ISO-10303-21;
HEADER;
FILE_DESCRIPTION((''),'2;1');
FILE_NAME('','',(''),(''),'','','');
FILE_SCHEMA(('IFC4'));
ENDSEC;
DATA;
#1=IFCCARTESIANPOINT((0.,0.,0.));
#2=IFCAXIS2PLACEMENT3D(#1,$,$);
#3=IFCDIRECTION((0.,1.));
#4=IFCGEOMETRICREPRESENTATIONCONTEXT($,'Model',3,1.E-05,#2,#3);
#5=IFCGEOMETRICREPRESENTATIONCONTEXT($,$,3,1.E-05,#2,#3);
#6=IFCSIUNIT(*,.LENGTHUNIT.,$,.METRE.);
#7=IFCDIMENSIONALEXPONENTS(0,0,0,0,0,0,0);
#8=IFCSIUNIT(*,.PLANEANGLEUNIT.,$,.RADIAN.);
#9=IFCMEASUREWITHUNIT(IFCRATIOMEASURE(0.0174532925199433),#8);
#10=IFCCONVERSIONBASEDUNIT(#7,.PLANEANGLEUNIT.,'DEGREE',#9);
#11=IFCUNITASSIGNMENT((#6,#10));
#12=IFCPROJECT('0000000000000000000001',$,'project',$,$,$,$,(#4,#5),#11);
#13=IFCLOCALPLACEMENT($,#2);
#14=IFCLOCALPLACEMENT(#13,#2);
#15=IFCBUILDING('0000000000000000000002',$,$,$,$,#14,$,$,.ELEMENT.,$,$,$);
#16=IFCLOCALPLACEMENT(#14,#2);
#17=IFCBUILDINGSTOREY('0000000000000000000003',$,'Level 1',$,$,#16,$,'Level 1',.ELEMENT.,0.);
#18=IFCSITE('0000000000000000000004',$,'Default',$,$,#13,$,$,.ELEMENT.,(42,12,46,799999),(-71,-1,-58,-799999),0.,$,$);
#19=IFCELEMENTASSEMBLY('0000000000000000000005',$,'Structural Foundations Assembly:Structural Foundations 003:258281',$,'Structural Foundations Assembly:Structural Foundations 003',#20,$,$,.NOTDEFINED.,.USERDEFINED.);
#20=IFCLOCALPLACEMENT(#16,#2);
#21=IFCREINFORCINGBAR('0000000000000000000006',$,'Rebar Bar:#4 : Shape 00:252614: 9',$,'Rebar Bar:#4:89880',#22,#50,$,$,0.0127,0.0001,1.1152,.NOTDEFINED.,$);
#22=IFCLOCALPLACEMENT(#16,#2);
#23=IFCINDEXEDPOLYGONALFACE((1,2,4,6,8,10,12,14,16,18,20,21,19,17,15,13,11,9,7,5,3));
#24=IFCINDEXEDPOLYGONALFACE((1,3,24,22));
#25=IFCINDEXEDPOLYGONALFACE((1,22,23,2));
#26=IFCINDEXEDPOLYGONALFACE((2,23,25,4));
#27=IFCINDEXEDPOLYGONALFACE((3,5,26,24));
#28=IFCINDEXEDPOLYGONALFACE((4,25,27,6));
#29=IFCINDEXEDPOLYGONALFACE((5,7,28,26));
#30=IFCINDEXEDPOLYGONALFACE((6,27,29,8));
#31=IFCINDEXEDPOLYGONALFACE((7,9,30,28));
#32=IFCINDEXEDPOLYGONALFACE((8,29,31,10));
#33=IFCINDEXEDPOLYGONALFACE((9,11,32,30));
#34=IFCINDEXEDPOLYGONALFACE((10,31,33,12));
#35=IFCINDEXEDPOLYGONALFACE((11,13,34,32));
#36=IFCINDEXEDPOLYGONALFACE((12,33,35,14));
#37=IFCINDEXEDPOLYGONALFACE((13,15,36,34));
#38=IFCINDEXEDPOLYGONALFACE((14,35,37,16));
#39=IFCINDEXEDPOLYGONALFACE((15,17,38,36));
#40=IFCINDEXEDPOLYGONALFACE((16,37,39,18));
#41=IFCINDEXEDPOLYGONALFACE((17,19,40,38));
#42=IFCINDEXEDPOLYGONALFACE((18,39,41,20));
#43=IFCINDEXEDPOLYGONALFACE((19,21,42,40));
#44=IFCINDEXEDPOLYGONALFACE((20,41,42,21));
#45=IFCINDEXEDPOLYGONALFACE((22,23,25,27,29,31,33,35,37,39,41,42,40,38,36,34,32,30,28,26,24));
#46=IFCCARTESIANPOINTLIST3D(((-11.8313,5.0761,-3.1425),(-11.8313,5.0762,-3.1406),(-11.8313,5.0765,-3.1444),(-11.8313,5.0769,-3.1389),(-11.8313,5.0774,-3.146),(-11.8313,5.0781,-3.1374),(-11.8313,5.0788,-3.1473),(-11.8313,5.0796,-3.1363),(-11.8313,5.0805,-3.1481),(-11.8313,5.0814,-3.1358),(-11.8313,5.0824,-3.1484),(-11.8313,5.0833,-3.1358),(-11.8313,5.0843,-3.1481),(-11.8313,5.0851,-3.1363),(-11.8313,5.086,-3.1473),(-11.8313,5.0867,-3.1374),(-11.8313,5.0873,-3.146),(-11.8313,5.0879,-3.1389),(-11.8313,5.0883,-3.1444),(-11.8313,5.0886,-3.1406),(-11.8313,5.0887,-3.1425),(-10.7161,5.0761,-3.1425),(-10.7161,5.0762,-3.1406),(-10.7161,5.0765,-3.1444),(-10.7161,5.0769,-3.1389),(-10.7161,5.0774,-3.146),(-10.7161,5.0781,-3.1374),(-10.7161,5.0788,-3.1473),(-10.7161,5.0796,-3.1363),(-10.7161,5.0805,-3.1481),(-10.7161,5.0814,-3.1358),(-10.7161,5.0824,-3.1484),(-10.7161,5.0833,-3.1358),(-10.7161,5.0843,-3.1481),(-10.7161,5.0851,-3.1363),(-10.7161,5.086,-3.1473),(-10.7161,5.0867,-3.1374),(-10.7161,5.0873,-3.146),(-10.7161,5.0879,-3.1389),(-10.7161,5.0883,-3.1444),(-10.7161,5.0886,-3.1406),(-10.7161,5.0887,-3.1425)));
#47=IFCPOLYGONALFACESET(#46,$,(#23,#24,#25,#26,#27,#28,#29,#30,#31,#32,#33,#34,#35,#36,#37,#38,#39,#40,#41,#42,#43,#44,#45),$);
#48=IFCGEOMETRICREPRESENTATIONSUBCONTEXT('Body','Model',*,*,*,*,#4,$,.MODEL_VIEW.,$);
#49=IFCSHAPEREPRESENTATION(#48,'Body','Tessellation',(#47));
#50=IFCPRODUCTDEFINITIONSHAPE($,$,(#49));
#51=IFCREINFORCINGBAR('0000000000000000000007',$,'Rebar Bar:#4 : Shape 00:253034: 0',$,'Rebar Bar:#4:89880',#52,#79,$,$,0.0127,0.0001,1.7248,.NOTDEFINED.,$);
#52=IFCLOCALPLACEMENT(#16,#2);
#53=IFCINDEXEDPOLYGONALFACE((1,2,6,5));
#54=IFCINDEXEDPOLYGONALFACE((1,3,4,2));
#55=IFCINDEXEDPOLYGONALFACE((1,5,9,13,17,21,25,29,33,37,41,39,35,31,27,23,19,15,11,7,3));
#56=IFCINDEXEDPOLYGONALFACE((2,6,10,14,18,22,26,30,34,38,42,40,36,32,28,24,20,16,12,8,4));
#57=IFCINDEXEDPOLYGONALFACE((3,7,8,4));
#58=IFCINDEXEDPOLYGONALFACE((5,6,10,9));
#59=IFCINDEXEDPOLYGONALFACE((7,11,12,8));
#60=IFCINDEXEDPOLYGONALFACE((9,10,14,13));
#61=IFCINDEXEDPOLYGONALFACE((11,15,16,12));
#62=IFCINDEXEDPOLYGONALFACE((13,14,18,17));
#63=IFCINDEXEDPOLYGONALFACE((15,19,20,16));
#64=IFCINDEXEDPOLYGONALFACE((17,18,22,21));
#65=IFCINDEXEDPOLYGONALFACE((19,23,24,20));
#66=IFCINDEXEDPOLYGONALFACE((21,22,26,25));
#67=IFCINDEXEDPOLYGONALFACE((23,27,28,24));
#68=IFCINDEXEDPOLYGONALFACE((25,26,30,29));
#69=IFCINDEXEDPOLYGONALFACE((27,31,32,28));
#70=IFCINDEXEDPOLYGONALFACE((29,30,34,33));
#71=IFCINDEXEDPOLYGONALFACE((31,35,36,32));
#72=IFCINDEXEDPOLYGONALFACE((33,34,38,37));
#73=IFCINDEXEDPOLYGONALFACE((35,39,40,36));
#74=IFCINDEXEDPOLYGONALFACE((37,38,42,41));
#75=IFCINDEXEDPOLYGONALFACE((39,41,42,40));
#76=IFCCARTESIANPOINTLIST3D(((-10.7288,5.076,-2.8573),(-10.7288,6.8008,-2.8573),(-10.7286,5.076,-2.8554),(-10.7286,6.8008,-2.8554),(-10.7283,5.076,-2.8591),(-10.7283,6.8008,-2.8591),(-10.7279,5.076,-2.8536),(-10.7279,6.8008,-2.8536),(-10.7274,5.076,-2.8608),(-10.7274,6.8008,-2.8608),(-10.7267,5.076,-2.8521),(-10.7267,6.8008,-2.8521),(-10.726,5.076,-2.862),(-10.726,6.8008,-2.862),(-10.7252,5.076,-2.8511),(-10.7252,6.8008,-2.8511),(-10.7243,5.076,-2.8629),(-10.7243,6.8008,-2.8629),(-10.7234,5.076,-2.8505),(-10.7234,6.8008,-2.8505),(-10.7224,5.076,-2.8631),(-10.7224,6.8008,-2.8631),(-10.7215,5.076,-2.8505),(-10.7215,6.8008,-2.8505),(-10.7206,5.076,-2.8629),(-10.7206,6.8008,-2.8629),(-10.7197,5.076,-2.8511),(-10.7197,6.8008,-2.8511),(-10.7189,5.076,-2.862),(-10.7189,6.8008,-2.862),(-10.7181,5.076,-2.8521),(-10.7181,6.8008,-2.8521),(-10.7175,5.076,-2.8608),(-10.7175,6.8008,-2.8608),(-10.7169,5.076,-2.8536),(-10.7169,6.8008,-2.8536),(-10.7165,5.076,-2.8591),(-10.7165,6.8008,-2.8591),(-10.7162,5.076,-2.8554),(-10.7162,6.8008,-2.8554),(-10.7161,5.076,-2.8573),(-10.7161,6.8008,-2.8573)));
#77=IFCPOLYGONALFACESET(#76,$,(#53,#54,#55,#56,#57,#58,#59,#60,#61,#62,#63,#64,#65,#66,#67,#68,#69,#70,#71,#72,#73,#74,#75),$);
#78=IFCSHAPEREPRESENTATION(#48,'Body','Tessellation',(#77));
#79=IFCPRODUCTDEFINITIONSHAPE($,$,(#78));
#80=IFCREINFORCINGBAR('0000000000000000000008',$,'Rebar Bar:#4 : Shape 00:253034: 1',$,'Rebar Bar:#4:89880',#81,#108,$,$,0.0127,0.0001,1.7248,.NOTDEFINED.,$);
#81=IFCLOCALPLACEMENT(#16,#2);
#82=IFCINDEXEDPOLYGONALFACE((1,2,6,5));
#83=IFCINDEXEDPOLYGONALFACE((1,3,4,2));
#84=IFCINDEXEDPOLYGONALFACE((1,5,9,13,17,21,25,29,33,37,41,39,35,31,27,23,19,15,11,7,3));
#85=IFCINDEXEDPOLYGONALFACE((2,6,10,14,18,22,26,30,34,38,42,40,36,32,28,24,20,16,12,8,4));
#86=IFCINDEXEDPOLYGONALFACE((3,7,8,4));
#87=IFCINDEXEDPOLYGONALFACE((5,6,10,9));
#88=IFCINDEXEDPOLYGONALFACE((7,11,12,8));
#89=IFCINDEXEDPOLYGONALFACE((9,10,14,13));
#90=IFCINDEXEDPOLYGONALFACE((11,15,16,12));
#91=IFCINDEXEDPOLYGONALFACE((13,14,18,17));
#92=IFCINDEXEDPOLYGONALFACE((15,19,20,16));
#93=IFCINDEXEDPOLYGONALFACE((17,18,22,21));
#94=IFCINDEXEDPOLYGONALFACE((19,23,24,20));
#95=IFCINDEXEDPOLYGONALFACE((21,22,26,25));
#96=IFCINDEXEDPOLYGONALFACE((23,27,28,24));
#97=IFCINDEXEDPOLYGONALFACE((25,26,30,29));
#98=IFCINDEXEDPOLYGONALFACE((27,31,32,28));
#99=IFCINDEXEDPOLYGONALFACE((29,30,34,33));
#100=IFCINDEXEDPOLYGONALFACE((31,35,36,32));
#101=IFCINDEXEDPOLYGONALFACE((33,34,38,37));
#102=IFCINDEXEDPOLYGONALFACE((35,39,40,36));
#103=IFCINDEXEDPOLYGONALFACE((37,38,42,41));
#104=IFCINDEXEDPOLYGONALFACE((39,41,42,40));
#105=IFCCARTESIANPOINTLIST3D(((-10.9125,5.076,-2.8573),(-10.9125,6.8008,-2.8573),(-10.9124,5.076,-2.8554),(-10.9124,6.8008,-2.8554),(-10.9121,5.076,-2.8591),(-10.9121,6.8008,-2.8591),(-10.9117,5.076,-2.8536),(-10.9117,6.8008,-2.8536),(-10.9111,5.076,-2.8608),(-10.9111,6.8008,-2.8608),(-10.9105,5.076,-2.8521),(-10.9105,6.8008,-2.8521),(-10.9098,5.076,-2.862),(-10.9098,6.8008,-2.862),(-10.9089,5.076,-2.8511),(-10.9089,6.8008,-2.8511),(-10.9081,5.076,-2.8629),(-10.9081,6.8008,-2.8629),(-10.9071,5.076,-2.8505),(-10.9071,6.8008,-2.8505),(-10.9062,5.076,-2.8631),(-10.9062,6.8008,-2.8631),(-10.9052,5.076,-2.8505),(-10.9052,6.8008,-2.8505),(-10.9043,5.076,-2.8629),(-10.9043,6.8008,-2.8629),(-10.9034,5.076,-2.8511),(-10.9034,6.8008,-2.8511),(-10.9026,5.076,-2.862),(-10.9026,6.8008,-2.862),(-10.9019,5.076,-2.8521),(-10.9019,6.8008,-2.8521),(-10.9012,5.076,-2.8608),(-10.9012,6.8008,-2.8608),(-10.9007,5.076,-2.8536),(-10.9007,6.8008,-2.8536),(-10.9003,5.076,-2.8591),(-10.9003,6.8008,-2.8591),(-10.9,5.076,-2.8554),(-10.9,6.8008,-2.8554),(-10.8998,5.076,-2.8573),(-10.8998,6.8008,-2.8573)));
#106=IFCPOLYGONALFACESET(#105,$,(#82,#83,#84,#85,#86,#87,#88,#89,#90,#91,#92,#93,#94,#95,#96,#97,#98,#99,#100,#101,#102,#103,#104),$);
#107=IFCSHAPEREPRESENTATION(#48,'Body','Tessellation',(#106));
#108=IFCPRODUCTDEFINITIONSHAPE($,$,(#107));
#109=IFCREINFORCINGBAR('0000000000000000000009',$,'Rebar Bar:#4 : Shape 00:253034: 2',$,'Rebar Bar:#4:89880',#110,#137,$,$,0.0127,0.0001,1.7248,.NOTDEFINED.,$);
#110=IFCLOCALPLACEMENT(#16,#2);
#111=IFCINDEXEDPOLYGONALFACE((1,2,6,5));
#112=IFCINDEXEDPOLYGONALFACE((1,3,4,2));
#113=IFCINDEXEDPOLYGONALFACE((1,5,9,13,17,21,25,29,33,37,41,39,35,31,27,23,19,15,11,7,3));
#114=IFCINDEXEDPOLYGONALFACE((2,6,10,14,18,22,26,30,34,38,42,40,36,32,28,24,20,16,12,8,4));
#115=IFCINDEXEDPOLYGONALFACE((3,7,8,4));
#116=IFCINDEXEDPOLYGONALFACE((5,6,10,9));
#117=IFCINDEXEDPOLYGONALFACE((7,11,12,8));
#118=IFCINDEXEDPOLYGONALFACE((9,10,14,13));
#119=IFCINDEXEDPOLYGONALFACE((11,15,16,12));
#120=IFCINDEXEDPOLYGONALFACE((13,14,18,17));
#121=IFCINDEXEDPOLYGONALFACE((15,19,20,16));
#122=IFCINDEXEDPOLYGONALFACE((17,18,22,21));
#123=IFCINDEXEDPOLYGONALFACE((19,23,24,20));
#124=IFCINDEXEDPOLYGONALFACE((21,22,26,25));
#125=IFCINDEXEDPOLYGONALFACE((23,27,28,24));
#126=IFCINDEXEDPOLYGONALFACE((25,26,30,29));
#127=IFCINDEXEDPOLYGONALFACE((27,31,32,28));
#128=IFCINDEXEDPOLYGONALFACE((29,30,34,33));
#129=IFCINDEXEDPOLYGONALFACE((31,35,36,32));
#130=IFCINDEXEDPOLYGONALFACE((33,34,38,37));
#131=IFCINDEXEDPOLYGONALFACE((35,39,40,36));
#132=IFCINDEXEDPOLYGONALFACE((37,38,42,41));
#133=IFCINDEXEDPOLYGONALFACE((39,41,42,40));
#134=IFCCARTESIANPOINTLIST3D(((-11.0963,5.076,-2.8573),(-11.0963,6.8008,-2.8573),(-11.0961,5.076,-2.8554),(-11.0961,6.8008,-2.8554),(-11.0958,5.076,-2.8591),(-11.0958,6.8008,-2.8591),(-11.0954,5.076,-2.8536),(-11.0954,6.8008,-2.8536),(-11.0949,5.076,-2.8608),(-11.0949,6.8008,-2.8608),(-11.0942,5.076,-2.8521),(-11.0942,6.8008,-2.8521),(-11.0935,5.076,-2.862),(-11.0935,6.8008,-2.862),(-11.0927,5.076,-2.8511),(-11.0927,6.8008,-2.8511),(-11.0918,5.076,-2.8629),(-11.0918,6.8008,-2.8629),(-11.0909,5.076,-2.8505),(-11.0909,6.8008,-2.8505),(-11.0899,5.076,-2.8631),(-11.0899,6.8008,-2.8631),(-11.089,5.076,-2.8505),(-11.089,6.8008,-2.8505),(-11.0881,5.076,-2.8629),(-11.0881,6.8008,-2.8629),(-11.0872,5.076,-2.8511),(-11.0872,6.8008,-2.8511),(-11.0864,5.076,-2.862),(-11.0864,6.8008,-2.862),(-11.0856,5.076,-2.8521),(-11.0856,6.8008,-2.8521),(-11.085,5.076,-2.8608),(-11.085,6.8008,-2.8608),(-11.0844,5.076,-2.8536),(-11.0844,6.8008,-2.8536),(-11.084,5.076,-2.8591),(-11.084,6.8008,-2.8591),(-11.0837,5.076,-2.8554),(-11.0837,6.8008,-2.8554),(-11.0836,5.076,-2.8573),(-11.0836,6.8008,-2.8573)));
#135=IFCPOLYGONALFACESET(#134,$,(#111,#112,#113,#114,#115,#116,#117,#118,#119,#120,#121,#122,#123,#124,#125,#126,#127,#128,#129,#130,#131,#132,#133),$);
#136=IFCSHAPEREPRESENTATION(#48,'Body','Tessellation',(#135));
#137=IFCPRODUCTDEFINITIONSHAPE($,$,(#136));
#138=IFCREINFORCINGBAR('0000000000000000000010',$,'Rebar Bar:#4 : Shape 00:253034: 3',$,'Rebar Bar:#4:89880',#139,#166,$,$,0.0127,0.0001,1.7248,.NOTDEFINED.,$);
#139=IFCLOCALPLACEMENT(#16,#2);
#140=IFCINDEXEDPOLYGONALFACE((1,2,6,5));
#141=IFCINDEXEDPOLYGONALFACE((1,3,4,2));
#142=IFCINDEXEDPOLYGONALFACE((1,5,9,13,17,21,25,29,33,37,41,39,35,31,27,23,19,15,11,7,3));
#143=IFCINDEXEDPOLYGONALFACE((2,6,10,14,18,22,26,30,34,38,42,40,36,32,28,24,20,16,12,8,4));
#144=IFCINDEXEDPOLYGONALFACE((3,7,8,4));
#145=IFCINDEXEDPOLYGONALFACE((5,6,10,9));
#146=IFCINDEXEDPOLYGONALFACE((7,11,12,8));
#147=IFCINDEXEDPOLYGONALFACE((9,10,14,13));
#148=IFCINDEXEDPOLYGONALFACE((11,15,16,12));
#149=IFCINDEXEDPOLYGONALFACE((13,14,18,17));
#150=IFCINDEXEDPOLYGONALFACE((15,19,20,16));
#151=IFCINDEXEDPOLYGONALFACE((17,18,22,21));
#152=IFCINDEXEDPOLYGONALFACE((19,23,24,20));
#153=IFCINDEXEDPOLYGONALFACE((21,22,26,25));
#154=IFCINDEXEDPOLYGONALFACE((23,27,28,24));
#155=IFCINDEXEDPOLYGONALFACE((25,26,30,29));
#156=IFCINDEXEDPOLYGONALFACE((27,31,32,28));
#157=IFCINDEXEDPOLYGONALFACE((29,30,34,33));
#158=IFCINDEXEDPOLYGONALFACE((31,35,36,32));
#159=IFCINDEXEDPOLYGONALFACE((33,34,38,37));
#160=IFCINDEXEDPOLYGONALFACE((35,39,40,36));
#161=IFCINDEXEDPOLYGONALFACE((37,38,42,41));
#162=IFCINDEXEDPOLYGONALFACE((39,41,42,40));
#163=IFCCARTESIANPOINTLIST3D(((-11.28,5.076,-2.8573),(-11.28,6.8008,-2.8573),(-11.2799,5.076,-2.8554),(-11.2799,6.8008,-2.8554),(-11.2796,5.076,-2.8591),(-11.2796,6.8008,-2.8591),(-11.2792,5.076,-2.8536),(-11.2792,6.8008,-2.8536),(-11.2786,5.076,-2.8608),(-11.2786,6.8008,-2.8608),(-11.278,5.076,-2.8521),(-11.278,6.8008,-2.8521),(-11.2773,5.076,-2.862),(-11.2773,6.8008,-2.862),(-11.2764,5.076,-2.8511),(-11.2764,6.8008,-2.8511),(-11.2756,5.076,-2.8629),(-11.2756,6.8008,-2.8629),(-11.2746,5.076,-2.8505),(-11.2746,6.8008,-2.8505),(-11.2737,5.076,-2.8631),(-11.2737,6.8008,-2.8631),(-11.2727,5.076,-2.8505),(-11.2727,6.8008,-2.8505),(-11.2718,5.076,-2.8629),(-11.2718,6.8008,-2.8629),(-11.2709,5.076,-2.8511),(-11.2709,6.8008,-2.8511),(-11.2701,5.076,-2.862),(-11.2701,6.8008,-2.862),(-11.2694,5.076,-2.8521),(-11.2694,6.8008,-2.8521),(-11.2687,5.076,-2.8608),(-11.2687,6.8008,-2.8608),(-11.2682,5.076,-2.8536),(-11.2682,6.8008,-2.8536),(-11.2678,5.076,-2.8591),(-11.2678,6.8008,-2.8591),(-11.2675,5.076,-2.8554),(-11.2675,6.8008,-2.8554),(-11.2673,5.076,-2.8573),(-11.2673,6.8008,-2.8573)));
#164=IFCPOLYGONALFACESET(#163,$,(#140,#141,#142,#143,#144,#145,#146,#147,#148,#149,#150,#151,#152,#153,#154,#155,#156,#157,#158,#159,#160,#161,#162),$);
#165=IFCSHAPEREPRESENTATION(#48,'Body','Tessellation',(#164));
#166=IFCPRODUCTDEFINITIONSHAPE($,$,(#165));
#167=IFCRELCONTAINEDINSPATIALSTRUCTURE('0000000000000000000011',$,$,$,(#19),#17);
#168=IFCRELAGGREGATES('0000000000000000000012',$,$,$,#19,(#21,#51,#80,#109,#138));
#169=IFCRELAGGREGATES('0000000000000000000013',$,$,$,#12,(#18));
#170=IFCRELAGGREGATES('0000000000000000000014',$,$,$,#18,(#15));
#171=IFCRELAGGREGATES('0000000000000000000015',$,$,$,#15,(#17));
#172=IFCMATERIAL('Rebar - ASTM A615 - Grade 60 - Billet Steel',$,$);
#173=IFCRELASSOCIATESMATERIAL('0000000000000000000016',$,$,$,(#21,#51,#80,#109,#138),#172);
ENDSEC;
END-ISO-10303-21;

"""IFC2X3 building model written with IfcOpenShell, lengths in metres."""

from ifc_helpers import new_model, entity, si_unit, converted_unit, direction, origin, place, context, subcontext, project, spatial, material, element, aggregate, save


model = new_model("IFC2X3")

# Units and contexts
model_context = context("Model", 3, precision=1e-05, world=origin(), true_north=direction((0.0, 1.0)))
context_of_model = context(None, 3, precision=1e-05, world=origin(), true_north=direction((0.0, 1.0)))
body_context = subcontext(model_context, "Body", "Model", "MODEL_VIEW")
ifc_project = project(units=[si_unit("LENGTHUNIT", "METRE"), converted_unit("PLANEANGLEUNIT", "DEGREE", entity("IfcRatioMeasure", 0.0174532925199433), si_unit("PLANEANGLEUNIT", "RADIAN"), dimensions=[0, 0, 0, 0, 0, 0, 0])], contexts=[model_context, context_of_model])

# Site, building, storey
site_placement = place(None, origin())
site = spatial("IfcSite", under=ifc_project, at=site_placement, Name="Default", CompositionType="ELEMENT", RefLatitude=(42, 12, 46, 799999), RefLongitude=(-71, -1, -58, -799999), RefElevation=0.0)
building_placement = place(site_placement, origin())
building = spatial("IfcBuilding", under=site, at=building_placement, CompositionType="ELEMENT")
storey_placement = place(building_placement, origin())
storey = spatial("IfcBuildingStorey", under=building, at=storey_placement, Name="Level 1", LongName="Level 1", CompositionType="ELEMENT", Elevation=0.0)

# Element assembly, reinforcing bars
assembly_1_placement = place(storey_placement, origin())
assembly_1 = element("IfcElementAssembly", 1, at=assembly_1_placement, inside=storey, Name="Structural Foundations Assembly:Structural Foundations 003:258281", ObjectType="Structural Foundations Assembly:Structural Foundations 003", AssemblyPlace="NOTDEFINED", PredefinedType="USERDEFINED")
ifc_material = material(Name="Rebar - ASTM A615 - Grade 60 - Billet Steel")
reinforcing_bar_1_placement = place(assembly_1_placement, origin())
reinforcing_bar_1 = element("IfcReinforcingBar", 2, at=reinforcing_bar_1_placement, material=ifc_material, Name="Rebar Bar:#4 : Shape 00:252614: 9", ObjectType="Rebar Bar:#4:89880", BarLength=1.1152, BarRole="NOTDEFINED", CrossSectionArea=0.0001, NominalDiameter=0.0127, context=body_context, shape_type="AdvancedSweptSolid", body=[
    entity("IfcSweptDiskSolid", entity("IfcCompositeCurve", [entity("IfcCompositeCurveSegment", "CONTINUOUS", True, entity("IfcPolyline", [entity("IfcCartesianPoint", [-10.7161, 5.0824, -3.142]), entity("IfcCartesianPoint", [-11.8313, 5.0824, -3.142])]))], False), 0.0063, None, 0.0, 1.0),
])
reinforcing_bar_2_placement = place(assembly_1_placement, origin())
reinforcing_bar_2 = element("IfcReinforcingBar", 3, at=reinforcing_bar_2_placement, material=ifc_material, Name="Rebar Bar:#4 : Shape 00:253034: 0", ObjectType="Rebar Bar:#4:89880", BarLength=1.7248, BarRole="NOTDEFINED", CrossSectionArea=0.0001, NominalDiameter=0.0127, context=body_context, shape_type="AdvancedSweptSolid", body=[
    entity("IfcSweptDiskSolid", entity("IfcCompositeCurve", [entity("IfcCompositeCurveSegment", "CONTINUOUS", True, entity("IfcPolyline", [entity("IfcCartesianPoint", [-10.7224, 6.8008, -2.8568]), entity("IfcCartesianPoint", [-10.7224, 5.076, -2.8568])]))], False), 0.0063, None, 0.0, 1.0),
])
reinforcing_bar_3_placement = place(assembly_1_placement, origin())
reinforcing_bar_3 = element("IfcReinforcingBar", 4, at=reinforcing_bar_3_placement, material=ifc_material, Name="Rebar Bar:#4 : Shape 00:253034: 1", ObjectType="Rebar Bar:#4:89880", BarLength=1.7248, BarRole="NOTDEFINED", CrossSectionArea=0.0001, NominalDiameter=0.0127, context=body_context, shape_type="AdvancedSweptSolid", body=[
    entity("IfcSweptDiskSolid", entity("IfcCompositeCurve", [entity("IfcCompositeCurveSegment", "CONTINUOUS", True, entity("IfcPolyline", [entity("IfcCartesianPoint", [-10.9062, 6.8008, -2.8568]), entity("IfcCartesianPoint", [-10.9062, 5.076, -2.8568])]))], False), 0.0063, None, 0.0, 1.0),
])
reinforcing_bar_4_placement = place(assembly_1_placement, origin())
reinforcing_bar_4 = element("IfcReinforcingBar", 5, at=reinforcing_bar_4_placement, material=ifc_material, Name="Rebar Bar:#4 : Shape 00:253034: 2", ObjectType="Rebar Bar:#4:89880", BarLength=1.7248, BarRole="NOTDEFINED", CrossSectionArea=0.0001, NominalDiameter=0.0127, context=body_context, shape_type="AdvancedSweptSolid", body=[
    entity("IfcSweptDiskSolid", entity("IfcCompositeCurve", [entity("IfcCompositeCurveSegment", "CONTINUOUS", True, entity("IfcPolyline", [entity("IfcCartesianPoint", [-11.0899, 6.8008, -2.8568]), entity("IfcCartesianPoint", [-11.0899, 5.076, -2.8568])]))], False), 0.0063, None, 0.0, 1.0),
])
reinforcing_bar_5_placement = place(assembly_1_placement, origin())
reinforcing_bar_5 = element("IfcReinforcingBar", 6, at=reinforcing_bar_5_placement, material=ifc_material, Name="Rebar Bar:#4 : Shape 00:253034: 3", ObjectType="Rebar Bar:#4:89880", BarLength=1.7248, BarRole="NOTDEFINED", CrossSectionArea=0.0001, NominalDiameter=0.0127, context=body_context, shape_type="AdvancedSweptSolid", body=[
    entity("IfcSweptDiskSolid", entity("IfcCompositeCurve", [entity("IfcCompositeCurveSegment", "CONTINUOUS", True, entity("IfcPolyline", [entity("IfcCartesianPoint", [-11.2737, 6.8008, -2.8568]), entity("IfcCartesianPoint", [-11.2737, 5.076, -2.8568])]))], False), 0.0063, None, 0.0, 1.0),
])
aggregate(assembly_1, [reinforcing_bar_1, reinforcing_bar_2, reinforcing_bar_3, reinforcing_bar_4, reinforcing_bar_5])

save(model, "model.ifc")
